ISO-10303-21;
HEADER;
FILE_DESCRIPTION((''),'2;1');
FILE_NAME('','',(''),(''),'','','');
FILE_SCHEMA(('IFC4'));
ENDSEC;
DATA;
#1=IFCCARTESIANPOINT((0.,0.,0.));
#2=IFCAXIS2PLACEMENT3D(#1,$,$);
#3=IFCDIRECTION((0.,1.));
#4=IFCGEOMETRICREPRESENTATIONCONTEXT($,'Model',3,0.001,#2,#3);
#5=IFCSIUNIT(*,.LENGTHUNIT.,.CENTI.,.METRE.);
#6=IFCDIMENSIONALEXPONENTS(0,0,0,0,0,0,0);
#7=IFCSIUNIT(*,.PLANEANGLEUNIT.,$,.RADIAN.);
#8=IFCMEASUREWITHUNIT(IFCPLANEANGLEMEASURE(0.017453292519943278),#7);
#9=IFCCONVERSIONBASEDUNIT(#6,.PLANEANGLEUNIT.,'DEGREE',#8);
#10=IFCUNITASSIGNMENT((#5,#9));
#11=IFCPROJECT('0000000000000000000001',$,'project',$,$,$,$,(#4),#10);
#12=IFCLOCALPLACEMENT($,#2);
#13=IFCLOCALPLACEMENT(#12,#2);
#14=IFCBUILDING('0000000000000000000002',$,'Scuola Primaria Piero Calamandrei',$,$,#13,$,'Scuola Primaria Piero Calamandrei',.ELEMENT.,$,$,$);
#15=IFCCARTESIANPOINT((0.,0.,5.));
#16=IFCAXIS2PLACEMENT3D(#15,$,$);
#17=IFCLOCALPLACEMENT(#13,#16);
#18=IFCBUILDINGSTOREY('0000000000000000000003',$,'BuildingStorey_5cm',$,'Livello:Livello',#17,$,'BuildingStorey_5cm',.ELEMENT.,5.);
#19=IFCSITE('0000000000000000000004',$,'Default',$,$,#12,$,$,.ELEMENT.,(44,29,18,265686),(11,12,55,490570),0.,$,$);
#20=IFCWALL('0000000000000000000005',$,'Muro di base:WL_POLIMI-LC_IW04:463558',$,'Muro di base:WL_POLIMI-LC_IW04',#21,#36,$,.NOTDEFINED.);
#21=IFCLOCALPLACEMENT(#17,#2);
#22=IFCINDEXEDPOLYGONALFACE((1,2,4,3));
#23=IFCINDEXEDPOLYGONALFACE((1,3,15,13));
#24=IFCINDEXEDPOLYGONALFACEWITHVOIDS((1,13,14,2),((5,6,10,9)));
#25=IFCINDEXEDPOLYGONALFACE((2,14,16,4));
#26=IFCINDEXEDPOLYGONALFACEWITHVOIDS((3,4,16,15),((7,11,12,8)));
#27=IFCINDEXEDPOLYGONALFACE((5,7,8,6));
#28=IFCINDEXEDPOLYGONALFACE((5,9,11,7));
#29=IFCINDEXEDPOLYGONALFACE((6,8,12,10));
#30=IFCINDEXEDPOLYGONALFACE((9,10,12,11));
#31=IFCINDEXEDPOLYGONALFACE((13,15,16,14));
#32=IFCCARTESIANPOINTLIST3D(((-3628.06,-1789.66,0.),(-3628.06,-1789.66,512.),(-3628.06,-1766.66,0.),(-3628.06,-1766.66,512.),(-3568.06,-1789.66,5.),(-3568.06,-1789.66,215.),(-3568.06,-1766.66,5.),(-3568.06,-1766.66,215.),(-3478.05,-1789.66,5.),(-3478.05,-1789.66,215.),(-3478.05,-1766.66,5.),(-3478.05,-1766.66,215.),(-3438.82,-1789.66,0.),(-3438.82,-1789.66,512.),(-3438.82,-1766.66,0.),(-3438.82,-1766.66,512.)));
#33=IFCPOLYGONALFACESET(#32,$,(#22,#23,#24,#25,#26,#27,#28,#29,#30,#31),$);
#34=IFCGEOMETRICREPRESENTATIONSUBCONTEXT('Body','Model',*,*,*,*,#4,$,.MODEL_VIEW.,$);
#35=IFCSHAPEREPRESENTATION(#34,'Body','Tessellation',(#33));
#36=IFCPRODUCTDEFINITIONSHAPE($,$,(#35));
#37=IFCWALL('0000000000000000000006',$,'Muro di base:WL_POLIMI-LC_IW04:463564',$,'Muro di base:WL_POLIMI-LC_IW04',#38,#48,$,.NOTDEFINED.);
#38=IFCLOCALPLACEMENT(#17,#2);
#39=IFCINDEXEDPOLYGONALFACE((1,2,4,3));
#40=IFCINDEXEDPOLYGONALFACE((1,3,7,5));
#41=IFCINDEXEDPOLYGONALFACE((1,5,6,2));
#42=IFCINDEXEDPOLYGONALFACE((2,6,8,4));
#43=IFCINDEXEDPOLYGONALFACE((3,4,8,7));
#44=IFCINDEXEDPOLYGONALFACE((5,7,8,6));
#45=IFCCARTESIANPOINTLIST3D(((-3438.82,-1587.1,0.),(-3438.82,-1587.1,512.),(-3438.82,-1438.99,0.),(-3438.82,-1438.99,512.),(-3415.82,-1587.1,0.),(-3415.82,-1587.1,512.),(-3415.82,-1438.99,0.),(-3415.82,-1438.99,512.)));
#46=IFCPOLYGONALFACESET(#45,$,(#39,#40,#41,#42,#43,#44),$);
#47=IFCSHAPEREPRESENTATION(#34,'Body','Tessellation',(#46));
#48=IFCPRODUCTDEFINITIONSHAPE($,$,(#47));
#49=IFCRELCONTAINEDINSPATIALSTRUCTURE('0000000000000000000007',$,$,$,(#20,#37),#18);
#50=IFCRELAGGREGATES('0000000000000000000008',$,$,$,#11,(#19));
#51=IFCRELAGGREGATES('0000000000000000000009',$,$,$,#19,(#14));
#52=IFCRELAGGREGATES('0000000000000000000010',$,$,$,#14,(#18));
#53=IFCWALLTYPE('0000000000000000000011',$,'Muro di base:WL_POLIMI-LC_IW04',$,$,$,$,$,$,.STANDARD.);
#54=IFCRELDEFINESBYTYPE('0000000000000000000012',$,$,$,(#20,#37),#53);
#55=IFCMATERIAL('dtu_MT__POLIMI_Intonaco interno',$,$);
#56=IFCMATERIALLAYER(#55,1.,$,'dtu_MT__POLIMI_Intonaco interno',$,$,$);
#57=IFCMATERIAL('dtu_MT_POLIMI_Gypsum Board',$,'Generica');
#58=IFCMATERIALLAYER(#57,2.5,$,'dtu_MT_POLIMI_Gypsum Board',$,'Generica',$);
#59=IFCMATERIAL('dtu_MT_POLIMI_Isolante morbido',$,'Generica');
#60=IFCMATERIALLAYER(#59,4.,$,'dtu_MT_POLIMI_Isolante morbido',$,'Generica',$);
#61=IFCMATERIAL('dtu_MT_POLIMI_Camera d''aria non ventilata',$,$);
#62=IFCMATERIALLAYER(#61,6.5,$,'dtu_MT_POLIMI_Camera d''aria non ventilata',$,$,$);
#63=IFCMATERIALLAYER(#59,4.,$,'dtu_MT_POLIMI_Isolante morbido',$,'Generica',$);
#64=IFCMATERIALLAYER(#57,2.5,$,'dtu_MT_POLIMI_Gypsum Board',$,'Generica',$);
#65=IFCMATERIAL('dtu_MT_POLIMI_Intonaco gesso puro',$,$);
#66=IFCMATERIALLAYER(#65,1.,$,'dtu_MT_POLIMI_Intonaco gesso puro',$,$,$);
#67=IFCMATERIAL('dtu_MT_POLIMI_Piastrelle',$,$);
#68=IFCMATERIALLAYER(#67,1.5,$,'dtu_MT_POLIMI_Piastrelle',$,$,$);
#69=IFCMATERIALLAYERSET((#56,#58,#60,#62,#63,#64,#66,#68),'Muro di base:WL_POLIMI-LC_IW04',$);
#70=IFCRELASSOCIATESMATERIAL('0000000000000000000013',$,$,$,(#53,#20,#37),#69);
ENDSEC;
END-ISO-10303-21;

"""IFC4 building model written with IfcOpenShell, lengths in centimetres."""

from ifc_helpers import new_model, entity, si_unit, converted_unit, direction, frame, frame_2d, origin, place, context, subcontext, project, spatial, rectangle, extrude, material, layer, layer_set, layer_usage, type_object, element, save


model = new_model("IFC4")

# Units and contexts
model_context = context("Model", 3, precision=0.001, world=origin(), true_north=direction((0.0, 1.0)))
body_context = subcontext(model_context, "Body", "Model", "MODEL_VIEW")
ifc_project = project(units=[si_unit("LENGTHUNIT", "METRE", prefix="CENTI"), converted_unit("PLANEANGLEUNIT", "DEGREE", entity("IfcPlaneAngleMeasure", 0.017453292519943278), si_unit("PLANEANGLEUNIT", "RADIAN"), dimensions=[0, 0, 0, 0, 0, 0, 0])], contexts=[model_context])

# Site, building, storey
site_placement = place(None, origin())
site = spatial("IfcSite", under=ifc_project, at=site_placement, Name="Default", CompositionType="ELEMENT", RefLatitude=(44, 29, 18, 265686), RefLongitude=(11, 12, 55, 490570), RefElevation=0.0)
building_placement = place(site_placement, origin())
building = spatial("IfcBuilding", under=site, at=building_placement, Name="Scuola Primaria Piero Calamandrei", LongName="Scuola Primaria Piero Calamandrei", CompositionType="ELEMENT")
storey_placement = place(building_placement, frame((0.0, 0.0, 5.0)))
storey = spatial("IfcBuildingStorey", under=building, at=storey_placement, Name="BuildingStorey_5cm", ObjectType="Livello:Livello", LongName="BuildingStorey_5cm", CompositionType="ELEMENT", Elevation=5.0)

# Shared definitions
ifc_material_1 = material(Name="dtu_MT_POLIMI_Intonaco gesso puro")

# Shared definitions
ifc_material_2 = material(Name="dtu_MT__POLIMI_Intonaco interno")

# Shared definitions
ifc_material_3 = material(Name="dtu_MT_POLIMI_Gypsum Board", Category="Generica")
ifc_material_4 = material(Name="dtu_MT_POLIMI_Isolante morbido", Category="Generica")
ifc_material_5 = material(Name="dtu_MT_POLIMI_Camera d'aria non ventilata")

# Shared definitions
ifc_layer_1 = layer(ifc_material_2, 1.0, Name="dtu_MT__POLIMI_Intonaco interno")
ifc_layer_2 = layer(ifc_material_3, 2.5, Name="dtu_MT_POLIMI_Gypsum Board", Category="Generica")
ifc_layer_3 = layer(ifc_material_4, 4.0, Name="dtu_MT_POLIMI_Isolante morbido", Category="Generica")
ifc_layer_4 = layer(ifc_material_5, 6.5, Name="dtu_MT_POLIMI_Camera d'aria non ventilata")
ifc_layer_5 = layer(ifc_material_4, 4.0, Name="dtu_MT_POLIMI_Isolante morbido", Category="Generica")
ifc_layer_6 = layer(ifc_material_3, 2.5, Name="dtu_MT_POLIMI_Gypsum Board", Category="Generica")
ifc_layer_7 = layer(ifc_material_1, 1.0, Name="dtu_MT_POLIMI_Intonaco gesso puro")
ifc_material_6 = material(Name="dtu_MT_POLIMI_Piastrelle")
ifc_layer_8 = layer(ifc_material_6, 1.5, Name="dtu_MT_POLIMI_Piastrelle")
ifc_layer_set_1 = layer_set([ifc_layer_1, ifc_layer_2, ifc_layer_3, ifc_layer_4, ifc_layer_5, ifc_layer_6, ifc_layer_7, ifc_layer_8], Name="Muro di base:WL_POLIMI-LC_IW04")
wall_type_1 = type_object("IfcWallType", Name="Muro di base:WL_POLIMI-LC_IW04", PredefinedType="STANDARD", material=ifc_layer_set_1)

# Wall, opening
ifc_layer_usage_1 = layer_usage(ifc_layer_set_1, "AXIS2", "NEGATIVE", 11.5)
wall_1_placement = place(storey_placement, frame((-3438.82, -1778.16, 0.0), z_axis=(0.0, 0.0, 1.0), x_axis=(-1.0, 0.0, 0.0)))
wall_1 = element("IfcWall", 1, at=wall_1_placement, inside=storey, type_object=wall_type_1, material=ifc_layer_usage_1, Name="Muro di base:WL_POLIMI-LC_IW04:463558", ObjectType="Muro di base:WL_POLIMI-LC_IW04", PredefinedType="NOTDEFINED", context=body_context, shape_type="SweptSolid", body=[
    extrude(rectangle(XDim=189.23, YDim=23.0, at=frame_2d((94.62, 0.0), x_axis=(-1.0, 0.0))), origin(), (0.0, 0.0, 1.0), 512.0),
])
opening_1_placement = place(wall_1_placement, frame((129.23, 11.5, 5.0)))
element("IfcOpeningElement", 2, at=opening_1_placement, cuts=wall_1, PredefinedType="OPENING", context=body_context, shape_type="SweptSolid", body=[
    extrude(rectangle(XDim=210.0, YDim=90.0, at=frame_2d((105.0, 45.0), x_axis=(-1.0, 0.0))), frame((0.0, 0.0, 0.0), z_axis=(0.0, -1.0, 0.0), x_axis=(0.0, 0.0, 1.0)), (0.0, 0.0, 1.0), 23.0),
])

# Wall
ifc_layer_usage_2 = layer_usage(ifc_layer_set_1, "AXIS2", "NEGATIVE", 11.5)
wall_2_placement = place(storey_placement, frame((-3427.32, -1587.1, 0.0), z_axis=(0.0, 0.0, 1.0), x_axis=(0.0, 1.0, 0.0)))
element("IfcWall", 3, at=wall_2_placement, inside=storey, type_object=wall_type_1, material=ifc_layer_usage_2, Name="Muro di base:WL_POLIMI-LC_IW04:463564", ObjectType="Muro di base:WL_POLIMI-LC_IW04", PredefinedType="NOTDEFINED", context=body_context, shape_type="SweptSolid", body=[
    extrude(rectangle(XDim=148.11, YDim=23.0, at=frame_2d((74.05, 0.0), x_axis=(-1.0, 0.0))), origin(), (0.0, 0.0, 1.0), 512.0),
])

save(model, "model.ifc")
